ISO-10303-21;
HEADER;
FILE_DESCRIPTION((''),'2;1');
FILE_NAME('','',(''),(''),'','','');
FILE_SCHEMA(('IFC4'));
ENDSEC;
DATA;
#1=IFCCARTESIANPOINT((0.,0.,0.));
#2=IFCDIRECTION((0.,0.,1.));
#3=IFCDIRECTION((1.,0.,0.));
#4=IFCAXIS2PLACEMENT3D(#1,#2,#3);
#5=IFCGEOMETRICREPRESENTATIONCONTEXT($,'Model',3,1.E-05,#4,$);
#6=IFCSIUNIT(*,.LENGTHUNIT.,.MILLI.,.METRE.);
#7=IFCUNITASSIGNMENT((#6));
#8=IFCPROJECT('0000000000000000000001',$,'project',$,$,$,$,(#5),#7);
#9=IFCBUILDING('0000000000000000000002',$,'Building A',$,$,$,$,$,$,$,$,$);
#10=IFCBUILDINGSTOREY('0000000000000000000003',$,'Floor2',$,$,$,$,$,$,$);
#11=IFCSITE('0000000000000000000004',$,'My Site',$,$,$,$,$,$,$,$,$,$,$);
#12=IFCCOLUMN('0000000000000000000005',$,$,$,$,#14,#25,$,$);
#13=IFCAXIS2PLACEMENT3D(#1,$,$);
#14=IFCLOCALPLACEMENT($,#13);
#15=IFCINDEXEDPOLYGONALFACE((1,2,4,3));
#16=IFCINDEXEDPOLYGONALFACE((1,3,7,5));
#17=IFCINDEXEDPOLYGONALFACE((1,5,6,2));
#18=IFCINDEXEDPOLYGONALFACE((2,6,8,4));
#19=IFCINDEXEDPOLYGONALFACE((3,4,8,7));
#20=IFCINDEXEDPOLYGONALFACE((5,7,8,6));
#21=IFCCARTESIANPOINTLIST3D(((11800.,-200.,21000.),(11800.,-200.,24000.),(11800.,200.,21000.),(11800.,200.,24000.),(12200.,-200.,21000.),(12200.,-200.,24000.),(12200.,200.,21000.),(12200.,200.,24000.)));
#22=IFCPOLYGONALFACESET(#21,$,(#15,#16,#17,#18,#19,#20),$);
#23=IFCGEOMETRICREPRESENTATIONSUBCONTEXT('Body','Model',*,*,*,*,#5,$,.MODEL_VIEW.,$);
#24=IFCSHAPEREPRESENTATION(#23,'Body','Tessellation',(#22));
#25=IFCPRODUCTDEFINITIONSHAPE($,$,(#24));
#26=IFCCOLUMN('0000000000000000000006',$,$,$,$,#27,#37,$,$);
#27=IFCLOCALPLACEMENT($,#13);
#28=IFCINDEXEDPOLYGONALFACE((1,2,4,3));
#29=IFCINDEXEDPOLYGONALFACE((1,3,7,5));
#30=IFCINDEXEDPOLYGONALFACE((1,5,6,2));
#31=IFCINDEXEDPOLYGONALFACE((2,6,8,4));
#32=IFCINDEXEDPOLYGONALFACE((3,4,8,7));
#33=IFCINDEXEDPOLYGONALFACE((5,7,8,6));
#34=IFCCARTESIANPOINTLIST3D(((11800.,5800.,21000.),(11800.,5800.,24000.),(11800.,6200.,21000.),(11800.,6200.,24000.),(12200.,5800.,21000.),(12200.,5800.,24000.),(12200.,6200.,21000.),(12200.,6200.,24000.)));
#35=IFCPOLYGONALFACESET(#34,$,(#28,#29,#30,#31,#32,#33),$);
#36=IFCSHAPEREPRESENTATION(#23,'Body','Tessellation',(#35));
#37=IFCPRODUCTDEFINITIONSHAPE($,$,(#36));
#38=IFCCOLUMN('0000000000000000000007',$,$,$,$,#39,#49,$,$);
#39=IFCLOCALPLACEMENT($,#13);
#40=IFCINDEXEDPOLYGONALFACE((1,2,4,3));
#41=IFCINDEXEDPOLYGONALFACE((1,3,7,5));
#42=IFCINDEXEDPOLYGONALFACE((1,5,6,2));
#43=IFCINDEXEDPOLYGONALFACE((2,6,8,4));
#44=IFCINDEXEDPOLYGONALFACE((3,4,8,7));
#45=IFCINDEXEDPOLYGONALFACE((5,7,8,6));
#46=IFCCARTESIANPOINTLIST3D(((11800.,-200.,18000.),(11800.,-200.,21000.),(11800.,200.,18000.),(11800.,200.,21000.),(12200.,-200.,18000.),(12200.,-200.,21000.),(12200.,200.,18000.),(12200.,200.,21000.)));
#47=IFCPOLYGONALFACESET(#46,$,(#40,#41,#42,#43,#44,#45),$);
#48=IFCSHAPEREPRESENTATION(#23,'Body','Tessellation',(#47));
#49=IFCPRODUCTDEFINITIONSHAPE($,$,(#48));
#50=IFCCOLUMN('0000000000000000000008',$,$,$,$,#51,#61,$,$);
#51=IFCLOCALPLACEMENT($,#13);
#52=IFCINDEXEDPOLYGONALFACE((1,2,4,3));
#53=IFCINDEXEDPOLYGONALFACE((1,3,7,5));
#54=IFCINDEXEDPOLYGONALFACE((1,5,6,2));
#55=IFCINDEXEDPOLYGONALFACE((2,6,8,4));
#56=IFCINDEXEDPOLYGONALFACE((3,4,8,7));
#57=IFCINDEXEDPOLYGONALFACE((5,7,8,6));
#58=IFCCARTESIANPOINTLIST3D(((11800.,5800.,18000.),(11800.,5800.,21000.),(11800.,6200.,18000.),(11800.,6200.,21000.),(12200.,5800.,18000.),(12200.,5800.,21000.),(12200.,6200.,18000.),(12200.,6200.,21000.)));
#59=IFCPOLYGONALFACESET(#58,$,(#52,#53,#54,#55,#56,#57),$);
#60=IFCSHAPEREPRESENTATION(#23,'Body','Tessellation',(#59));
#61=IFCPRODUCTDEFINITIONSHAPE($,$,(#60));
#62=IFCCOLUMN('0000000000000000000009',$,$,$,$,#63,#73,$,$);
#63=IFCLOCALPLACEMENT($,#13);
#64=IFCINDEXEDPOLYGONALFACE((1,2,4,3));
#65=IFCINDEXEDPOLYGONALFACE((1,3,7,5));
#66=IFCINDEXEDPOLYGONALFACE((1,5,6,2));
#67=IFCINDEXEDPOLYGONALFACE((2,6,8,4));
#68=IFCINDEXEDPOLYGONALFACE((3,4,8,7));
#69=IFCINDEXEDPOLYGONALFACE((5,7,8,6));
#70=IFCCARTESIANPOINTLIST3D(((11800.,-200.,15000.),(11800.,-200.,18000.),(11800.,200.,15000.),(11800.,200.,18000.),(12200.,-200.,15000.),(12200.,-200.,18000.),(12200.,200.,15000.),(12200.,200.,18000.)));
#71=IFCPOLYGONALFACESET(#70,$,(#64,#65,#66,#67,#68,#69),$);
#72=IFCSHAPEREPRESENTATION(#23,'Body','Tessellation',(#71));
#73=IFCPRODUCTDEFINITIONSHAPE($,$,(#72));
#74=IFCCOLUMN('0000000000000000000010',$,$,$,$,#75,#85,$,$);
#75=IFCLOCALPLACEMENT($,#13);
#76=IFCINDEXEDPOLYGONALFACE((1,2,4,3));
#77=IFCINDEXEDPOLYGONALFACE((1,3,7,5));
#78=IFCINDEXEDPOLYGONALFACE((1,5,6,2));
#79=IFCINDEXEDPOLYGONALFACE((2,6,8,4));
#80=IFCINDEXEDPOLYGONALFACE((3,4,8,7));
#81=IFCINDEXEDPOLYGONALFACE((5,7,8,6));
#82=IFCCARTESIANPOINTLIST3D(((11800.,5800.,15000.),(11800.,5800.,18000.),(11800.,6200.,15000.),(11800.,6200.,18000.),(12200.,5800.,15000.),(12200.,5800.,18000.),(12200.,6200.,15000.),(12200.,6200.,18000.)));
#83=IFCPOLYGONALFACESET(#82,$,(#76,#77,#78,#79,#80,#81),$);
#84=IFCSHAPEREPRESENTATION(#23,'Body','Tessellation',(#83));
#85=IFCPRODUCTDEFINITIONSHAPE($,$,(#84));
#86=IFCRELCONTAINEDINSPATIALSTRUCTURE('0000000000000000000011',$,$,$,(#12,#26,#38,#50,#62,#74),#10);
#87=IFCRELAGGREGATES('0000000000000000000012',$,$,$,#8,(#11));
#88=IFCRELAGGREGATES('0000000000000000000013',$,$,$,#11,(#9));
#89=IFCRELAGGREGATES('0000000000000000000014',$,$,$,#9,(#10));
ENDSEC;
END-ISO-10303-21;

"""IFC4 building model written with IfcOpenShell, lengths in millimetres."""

from ifc_helpers import new_model, si_unit, frame, origin_with_axes, place, context, subcontext, project, spatial, line, indexed_curve, outline, extrude, element, save


model = new_model("IFC4")

# Units and contexts
model_context = context("Model", 3, precision=1e-05, world=origin_with_axes())
body_context = subcontext(model_context, "Body", "Model", "MODEL_VIEW")
ifc_project = project(units=[si_unit("LENGTHUNIT", "METRE", prefix="MILLI")], contexts=[model_context])

# Site, building, storey
site = spatial("IfcSite", under=ifc_project, Name="My Site")
building = spatial("IfcBuilding", under=site, Name="Building A")
storey = spatial("IfcBuildingStorey", under=building, Name="Floor2")

# Columns
for number, where, z_axis, x_axis in (
    (1, (12000.0, 0.0, 21000.0), (0.0, 0.0, 1.0), (1.0, 0.0, 0.0)),
    (2, (12000.0, 6000.0, 21000.0), (0.0, 0.0, 1.0), (1.0, 0.0, 0.0)),
    (3, (12000.0, 0.0, 18000.0), (0.0, 0.0, 1.0), (1.0, 0.0, 0.0)),
    (4, (12000.0, 6000.0, 18000.0), (0.0, 0.0, 1.0), (1.0, 0.0, 0.0)),
    (5, (12000.0, 0.0, 15000.0), (0.0, 0.0, 1.0), (1.0, 0.0, 0.0)),
    (6, (12000.0, 6000.0, 15000.0), (0.0, 0.0, 1.0), (1.0, 0.0, 0.0)),
):
    element("IfcColumn", number, at=place(None, frame(where, z_axis=z_axis, x_axis=x_axis)), inside=storey, context=body_context, shape_type="SweptSolid", body=[
        extrude(outline(indexed_curve([(-200.0, -200.0), (200.0, -200.0), (200.0, 200.0), (-200.0, 200.0)], segments=[line(1, 2, 3, 4, 1)])), origin_with_axes(), (0.0, 0.0, 1.0), 3000.0),
    ])

save(model, "model.ifc")
